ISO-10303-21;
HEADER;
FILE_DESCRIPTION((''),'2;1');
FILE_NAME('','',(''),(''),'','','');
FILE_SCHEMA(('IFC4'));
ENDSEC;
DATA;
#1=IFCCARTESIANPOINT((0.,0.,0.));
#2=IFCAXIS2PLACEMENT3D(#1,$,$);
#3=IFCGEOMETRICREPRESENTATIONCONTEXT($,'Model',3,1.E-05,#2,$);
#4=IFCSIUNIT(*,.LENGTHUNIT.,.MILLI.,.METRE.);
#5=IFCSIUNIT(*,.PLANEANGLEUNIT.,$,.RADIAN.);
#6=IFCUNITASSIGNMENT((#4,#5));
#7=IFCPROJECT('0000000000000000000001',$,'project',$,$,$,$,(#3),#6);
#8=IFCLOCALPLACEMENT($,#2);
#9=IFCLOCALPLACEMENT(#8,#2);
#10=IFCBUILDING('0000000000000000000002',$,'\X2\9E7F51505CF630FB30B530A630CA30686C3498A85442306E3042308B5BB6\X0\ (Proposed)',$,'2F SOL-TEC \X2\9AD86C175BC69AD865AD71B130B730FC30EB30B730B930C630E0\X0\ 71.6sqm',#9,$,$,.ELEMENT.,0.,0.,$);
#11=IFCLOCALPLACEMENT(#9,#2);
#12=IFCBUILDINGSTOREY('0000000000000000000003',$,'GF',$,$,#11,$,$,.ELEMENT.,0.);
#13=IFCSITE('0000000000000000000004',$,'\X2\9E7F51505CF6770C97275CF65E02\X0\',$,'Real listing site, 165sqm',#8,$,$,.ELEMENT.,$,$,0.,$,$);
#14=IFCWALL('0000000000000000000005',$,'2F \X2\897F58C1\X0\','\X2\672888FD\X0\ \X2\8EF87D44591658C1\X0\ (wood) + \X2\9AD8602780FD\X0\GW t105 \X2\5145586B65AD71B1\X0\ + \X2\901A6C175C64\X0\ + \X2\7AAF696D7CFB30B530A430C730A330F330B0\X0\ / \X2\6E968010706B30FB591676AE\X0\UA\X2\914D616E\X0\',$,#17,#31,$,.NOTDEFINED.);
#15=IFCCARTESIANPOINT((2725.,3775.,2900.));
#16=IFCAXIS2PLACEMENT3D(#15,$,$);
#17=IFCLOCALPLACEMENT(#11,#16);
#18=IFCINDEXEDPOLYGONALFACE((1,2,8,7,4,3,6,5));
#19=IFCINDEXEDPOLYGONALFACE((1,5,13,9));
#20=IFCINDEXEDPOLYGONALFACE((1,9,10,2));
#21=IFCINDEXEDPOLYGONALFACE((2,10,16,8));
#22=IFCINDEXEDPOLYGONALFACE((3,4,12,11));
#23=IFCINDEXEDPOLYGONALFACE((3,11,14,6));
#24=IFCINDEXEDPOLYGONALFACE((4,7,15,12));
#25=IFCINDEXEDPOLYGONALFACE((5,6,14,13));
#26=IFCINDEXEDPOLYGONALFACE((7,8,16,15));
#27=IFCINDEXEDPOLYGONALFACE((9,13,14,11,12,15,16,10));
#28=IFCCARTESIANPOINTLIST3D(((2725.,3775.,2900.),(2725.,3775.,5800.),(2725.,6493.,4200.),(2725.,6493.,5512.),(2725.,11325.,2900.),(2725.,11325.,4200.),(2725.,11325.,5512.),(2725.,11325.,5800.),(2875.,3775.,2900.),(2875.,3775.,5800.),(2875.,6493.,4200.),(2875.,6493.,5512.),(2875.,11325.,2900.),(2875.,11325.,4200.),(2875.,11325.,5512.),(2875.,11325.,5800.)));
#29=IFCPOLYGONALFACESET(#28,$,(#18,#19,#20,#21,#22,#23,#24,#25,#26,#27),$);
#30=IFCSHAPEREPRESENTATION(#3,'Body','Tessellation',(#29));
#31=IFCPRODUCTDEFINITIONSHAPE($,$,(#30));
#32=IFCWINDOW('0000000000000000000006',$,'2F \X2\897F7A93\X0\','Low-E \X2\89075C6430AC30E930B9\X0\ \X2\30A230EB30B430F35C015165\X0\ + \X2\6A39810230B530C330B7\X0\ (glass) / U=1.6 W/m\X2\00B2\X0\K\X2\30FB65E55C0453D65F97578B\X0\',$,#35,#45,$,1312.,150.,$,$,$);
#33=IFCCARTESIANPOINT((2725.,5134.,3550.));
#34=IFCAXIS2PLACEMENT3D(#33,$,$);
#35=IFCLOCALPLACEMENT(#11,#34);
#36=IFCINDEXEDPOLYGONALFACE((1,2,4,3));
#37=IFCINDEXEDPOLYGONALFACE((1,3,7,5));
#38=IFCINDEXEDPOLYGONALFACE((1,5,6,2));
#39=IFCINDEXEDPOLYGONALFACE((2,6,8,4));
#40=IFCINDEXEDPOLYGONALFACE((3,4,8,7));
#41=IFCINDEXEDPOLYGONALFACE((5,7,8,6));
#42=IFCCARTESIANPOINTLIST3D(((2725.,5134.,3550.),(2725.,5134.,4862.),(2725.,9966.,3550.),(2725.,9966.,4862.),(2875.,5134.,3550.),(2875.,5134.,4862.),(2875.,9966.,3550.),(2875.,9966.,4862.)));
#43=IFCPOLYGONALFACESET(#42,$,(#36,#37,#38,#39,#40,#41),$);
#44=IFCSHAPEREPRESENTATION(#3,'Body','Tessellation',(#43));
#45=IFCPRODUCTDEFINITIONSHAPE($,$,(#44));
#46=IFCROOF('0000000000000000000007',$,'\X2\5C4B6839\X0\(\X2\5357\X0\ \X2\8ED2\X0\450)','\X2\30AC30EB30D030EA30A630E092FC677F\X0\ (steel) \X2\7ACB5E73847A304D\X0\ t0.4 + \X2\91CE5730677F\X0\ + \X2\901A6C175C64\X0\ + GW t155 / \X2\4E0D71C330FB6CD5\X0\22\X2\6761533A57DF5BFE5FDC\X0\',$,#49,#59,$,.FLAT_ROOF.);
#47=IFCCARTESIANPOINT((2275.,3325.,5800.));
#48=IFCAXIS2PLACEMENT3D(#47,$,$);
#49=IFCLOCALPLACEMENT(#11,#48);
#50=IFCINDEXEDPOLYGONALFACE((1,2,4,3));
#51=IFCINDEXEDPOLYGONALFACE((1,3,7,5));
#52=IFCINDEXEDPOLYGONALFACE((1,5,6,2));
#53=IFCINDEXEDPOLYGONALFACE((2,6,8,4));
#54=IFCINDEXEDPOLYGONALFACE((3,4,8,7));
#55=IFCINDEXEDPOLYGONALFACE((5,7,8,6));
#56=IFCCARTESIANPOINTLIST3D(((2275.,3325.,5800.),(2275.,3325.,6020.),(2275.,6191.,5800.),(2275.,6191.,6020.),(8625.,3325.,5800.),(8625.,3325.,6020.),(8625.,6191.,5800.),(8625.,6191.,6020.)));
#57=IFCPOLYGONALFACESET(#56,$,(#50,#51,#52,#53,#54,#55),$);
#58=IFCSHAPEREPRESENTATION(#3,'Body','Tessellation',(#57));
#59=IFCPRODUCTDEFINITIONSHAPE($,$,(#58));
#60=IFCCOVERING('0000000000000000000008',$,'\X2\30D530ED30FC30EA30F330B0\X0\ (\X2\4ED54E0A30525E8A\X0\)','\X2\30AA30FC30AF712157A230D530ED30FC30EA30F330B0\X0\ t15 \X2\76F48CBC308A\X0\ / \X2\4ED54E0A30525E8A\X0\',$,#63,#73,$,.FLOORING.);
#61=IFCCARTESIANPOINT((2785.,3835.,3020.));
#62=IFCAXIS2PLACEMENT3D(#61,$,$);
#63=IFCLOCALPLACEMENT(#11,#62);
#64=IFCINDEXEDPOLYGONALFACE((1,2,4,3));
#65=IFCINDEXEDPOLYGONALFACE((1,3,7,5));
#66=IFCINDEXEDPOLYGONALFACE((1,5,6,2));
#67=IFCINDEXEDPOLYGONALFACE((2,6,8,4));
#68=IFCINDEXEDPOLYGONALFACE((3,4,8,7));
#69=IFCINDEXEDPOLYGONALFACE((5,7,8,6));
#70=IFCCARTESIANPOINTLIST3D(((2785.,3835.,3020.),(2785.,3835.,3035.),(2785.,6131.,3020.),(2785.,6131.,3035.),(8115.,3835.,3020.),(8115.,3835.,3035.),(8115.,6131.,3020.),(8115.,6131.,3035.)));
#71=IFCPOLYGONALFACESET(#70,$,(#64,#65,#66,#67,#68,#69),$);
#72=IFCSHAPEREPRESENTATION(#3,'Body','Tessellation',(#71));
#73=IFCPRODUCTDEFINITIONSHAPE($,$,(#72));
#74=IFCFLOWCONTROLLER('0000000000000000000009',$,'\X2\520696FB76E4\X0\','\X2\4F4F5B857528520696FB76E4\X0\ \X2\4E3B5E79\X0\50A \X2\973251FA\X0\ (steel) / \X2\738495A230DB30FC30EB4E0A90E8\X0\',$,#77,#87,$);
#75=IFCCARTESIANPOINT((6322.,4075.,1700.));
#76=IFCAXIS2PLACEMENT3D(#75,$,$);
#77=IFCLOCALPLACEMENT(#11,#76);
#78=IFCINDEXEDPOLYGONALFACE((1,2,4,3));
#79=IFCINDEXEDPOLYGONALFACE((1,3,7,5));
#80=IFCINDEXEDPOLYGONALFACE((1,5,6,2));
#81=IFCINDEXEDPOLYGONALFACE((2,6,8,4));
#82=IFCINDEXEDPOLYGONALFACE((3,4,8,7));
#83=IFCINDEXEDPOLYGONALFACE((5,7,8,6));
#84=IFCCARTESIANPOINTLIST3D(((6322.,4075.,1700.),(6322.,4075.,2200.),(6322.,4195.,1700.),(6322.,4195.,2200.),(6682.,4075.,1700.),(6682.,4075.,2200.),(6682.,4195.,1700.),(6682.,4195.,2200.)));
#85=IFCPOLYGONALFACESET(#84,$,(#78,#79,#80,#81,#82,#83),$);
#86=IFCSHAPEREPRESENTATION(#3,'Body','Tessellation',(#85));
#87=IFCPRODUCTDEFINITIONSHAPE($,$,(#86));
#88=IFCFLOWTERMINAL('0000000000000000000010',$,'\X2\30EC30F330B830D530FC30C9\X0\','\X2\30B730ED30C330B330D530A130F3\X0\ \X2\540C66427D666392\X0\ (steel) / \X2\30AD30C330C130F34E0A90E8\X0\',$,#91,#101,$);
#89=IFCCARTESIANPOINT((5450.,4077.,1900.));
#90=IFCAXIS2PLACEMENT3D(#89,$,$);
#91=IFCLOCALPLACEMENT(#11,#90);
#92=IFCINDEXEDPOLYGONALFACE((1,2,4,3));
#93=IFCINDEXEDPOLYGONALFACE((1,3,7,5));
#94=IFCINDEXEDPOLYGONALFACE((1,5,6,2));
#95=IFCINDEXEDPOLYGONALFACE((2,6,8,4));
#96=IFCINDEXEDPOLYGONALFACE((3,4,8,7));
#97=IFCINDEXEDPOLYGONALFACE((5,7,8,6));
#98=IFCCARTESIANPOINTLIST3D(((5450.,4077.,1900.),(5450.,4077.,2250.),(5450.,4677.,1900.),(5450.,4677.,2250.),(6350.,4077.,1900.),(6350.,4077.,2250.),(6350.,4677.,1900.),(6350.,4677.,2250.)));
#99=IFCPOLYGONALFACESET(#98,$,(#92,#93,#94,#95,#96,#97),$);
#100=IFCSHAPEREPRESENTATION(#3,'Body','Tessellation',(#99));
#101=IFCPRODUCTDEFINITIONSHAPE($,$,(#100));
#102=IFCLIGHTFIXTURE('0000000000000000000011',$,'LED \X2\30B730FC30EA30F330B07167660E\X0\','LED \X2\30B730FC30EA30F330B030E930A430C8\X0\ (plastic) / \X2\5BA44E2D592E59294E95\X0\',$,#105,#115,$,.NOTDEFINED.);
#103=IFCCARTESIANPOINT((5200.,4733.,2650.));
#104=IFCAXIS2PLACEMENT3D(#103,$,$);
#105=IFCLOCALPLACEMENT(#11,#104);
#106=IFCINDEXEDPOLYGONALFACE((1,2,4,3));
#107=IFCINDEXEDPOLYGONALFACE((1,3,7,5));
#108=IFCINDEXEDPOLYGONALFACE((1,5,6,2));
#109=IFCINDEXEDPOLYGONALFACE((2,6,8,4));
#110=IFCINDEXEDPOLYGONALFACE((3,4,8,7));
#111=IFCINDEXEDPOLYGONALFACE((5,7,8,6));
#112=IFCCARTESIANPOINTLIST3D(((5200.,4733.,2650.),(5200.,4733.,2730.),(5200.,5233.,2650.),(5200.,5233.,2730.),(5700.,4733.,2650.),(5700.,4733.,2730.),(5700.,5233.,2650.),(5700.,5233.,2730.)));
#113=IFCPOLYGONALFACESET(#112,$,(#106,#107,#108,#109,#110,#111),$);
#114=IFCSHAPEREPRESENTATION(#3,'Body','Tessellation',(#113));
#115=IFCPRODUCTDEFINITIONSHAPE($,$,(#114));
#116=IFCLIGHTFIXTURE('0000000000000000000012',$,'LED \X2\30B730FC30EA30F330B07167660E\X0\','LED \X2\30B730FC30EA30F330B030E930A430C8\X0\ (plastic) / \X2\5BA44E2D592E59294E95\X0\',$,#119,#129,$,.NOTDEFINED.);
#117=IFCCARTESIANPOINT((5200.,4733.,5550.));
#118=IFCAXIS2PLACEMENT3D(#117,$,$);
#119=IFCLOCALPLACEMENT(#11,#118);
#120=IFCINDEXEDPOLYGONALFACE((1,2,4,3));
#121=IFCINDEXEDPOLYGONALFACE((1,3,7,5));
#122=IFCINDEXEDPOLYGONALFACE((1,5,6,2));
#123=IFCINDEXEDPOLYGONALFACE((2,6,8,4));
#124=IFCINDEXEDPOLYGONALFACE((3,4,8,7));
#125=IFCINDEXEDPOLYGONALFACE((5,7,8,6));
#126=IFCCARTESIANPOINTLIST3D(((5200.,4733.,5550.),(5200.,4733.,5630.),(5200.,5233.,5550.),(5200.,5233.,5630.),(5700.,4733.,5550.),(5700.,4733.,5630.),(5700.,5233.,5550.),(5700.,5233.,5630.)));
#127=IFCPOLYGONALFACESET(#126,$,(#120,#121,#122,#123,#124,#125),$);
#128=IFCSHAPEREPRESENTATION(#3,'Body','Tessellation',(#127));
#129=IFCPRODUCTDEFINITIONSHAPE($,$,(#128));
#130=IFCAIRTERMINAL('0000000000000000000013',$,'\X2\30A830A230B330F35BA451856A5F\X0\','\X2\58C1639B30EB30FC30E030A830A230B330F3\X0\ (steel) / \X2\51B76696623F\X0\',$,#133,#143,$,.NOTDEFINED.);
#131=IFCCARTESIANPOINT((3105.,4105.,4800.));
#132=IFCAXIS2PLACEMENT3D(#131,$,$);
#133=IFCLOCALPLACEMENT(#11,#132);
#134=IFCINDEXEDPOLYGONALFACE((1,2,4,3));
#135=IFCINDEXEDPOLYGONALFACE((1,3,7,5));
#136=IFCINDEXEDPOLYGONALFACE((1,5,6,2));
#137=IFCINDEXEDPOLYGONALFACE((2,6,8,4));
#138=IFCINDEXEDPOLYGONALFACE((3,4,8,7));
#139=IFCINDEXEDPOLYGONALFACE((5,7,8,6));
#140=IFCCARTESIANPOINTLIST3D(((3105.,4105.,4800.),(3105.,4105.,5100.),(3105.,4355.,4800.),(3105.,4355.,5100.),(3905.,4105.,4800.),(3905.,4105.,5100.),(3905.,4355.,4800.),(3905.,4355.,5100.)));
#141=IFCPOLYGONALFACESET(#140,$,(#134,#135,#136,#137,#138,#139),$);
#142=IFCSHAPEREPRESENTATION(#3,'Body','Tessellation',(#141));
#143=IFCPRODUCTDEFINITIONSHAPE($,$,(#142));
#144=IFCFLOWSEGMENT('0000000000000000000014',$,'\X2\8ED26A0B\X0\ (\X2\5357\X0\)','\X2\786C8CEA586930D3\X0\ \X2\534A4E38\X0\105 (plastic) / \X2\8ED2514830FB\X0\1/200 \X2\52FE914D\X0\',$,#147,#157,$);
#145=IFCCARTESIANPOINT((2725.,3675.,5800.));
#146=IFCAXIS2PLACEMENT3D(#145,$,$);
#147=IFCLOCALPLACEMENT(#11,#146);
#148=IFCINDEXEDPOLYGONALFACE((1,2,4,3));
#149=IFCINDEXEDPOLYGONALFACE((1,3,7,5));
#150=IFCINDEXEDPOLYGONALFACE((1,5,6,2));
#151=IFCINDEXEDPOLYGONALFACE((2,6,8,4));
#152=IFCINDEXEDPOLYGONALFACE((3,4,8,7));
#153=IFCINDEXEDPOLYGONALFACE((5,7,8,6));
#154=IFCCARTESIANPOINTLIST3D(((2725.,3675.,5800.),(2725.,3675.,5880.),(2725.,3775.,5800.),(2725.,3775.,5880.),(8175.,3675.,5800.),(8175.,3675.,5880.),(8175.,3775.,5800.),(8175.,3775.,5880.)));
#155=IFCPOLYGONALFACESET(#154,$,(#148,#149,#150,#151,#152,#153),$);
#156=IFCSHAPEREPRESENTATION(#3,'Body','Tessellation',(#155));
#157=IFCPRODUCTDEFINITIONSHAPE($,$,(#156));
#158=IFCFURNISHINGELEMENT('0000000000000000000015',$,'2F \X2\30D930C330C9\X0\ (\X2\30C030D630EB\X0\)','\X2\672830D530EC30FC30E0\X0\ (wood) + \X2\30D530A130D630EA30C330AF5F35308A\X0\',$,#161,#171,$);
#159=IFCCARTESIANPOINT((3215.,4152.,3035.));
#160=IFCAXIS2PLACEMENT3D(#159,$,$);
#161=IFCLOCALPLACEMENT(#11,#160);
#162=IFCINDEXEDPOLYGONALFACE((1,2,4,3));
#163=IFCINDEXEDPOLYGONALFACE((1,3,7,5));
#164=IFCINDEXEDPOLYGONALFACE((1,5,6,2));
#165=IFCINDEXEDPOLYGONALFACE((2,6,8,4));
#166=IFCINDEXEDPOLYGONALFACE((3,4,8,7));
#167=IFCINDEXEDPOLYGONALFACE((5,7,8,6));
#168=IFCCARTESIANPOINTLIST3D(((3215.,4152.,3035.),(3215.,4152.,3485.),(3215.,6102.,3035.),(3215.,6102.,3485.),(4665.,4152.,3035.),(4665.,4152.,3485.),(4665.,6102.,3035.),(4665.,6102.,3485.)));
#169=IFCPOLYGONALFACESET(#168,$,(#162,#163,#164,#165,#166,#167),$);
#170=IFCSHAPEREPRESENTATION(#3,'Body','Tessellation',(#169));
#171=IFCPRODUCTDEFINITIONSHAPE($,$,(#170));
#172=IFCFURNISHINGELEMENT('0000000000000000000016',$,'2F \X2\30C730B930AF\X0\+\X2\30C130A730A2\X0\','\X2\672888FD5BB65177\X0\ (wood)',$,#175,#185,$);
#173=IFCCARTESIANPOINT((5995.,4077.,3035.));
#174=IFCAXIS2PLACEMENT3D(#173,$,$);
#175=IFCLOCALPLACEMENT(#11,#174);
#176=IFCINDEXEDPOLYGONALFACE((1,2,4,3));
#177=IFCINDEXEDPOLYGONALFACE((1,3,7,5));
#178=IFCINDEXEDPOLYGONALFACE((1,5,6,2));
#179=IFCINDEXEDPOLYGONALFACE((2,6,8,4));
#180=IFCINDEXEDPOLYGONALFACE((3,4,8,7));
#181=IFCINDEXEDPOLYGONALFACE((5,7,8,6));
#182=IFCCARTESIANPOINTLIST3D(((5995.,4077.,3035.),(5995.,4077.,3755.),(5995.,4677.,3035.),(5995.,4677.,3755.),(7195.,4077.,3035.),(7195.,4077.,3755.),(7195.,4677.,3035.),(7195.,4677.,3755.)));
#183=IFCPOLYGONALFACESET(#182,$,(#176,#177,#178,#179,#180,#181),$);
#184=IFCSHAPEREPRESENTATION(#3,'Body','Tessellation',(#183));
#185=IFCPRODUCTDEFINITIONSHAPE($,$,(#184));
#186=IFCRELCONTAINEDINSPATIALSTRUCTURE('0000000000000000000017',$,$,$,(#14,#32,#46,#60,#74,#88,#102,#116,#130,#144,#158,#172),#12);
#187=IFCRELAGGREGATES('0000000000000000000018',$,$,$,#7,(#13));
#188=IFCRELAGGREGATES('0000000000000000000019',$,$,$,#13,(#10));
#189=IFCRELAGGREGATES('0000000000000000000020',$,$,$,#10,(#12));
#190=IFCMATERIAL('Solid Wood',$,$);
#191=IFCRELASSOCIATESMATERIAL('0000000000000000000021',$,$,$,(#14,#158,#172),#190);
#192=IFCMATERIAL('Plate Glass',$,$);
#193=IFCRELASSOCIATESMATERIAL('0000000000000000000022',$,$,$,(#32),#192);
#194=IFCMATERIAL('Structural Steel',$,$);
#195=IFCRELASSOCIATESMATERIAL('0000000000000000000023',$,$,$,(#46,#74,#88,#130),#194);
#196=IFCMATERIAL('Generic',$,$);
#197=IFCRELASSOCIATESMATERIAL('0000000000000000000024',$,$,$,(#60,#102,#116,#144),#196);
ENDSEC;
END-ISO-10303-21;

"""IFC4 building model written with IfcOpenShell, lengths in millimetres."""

from ifc_helpers import new_model, si_unit, frame, frame_2d, origin, place, context, project, spatial, rectangle, extrude, material, element, fill, save


model = new_model("IFC4")

# Units and contexts
model_context = context("Model", 3, precision=1e-05, world=origin())
ifc_project = project(units=[si_unit("LENGTHUNIT", "METRE", prefix="MILLI"), si_unit("PLANEANGLEUNIT", "RADIAN")], contexts=[model_context])

# Site, building, storey
site_placement = place(None, origin())
site = spatial("IfcSite", under=ifc_project, at=site_placement, Name="鹿児島県霧島市", ObjectType="Real listing site, 165sqm", CompositionType="ELEMENT", RefElevation=0.0)
building_placement = place(site_placement, origin())
building = spatial("IfcBuilding", under=site, at=building_placement, Name="鹿児島・サウナと水風呂のある家 (Proposed)", ObjectType="2F SOL-TEC 高気密高断熱シールシステム 71.6sqm", CompositionType="ELEMENT", ElevationOfRefHeight=0.0, ElevationOfTerrain=0.0)
storey_placement = place(building_placement, origin())
storey = spatial("IfcBuildingStorey", under=building, at=storey_placement, Name="GF", CompositionType="ELEMENT", Elevation=0.0)

# Shared definitions
ifc_material_1 = material(Name="Solid Wood")

# Wall, opening, window
ifc_material_2 = material(Name="Plate Glass")
wall_1_placement = place(storey_placement, frame((2725.0, 3775.0, 2900.0)))
wall_1 = element("IfcWall", 1, at=wall_1_placement, inside=storey, material=ifc_material_1, Name="2F 西壁", Description="木製 軸組外壁 (wood) + 高性能GW t105 充填断熱 + 通気層 + 窯業系サイディング / 準耐火・外皮UA配慮", PredefinedType="NOTDEFINED", context=model_context, shape_type="SweptSolid", body=[
    extrude(rectangle(XDim=150.0, YDim=7550.0, at=frame_2d((75.0, 3775.0))), frame((2725.0, 3775.0, 2900.0)), (0.0, 0.0, 1.0), 2900.0),
])
opening_1_placement = place(storey_placement, frame((2725.0, 5134.0, 3550.0)))
opening_1 = element("IfcOpeningElement", 2, at=opening_1_placement, cuts=wall_1, PredefinedType="NOTDEFINED", context=model_context, shape_type="SweptSolid", body=[
    extrude(rectangle(XDim=150.0, YDim=4832.0, at=frame_2d((75.0, 2416.0))), frame((2725.0, 5134.0, 3550.0)), (0.0, 0.0, 1.0), 1312.0),
])
window_1_placement = place(storey_placement, frame((2725.0, 5134.0, 3550.0)))
window_1 = element("IfcWindow", 3, at=window_1_placement, inside=storey, material=ifc_material_2, Name="2F 西窓", Description="Low-E 複層ガラス アルゴン封入 + 樹脂サッシ (glass) / U=1.6 W/m²K・日射取得型", OverallHeight=1312.0, OverallWidth=150.0, context=model_context, shape_type="SweptSolid", body=[
    extrude(rectangle(XDim=150.0, YDim=4832.0, at=frame_2d((75.0, 2416.0))), frame((2725.0, 5134.0, 3550.0)), (0.0, 0.0, 1.0), 1312.0),
])
fill(opening_1, window_1)

# Roof
ifc_material_3 = material(Name="Structural Steel")
for number, where, name in (
    (4, (2275.0, 3325.0, 5800.0), "屋根(南 軒450)"),
):
    element("IfcRoof", number, at=place(storey_placement, frame(where)), inside=storey, material=ifc_material_3, Name=name, Description="ガルバリウム鋼板 (steel) 立平葺き t0.4 + 野地板 + 通気層 + GW t155 / 不燃・法22条区域対応", PredefinedType="FLAT_ROOF", context=model_context, shape_type="SweptSolid", body=[
        extrude(rectangle(XDim=6350.0, YDim=2866.0, at=frame_2d((3175.0, 1433.0))), frame((2275.0, 3325.0, 5800.0)), (0.0, 0.0, 1.0), 220.0),
    ])

# Covering
ifc_material_4 = material(Name="Generic")
covering_placement = place(storey_placement, frame((2785.0, 3835.0, 3020.0)))
element("IfcCovering", 5, at=covering_placement, inside=storey, material=ifc_material_4, Name="フローリング (仕上げ床)", Description="オーク無垢フローリング t15 直貼り / 仕上げ床", PredefinedType="FLOORING", context=model_context, shape_type="SweptSolid", body=[
    extrude(rectangle(XDim=5330.0, YDim=2296.0, at=frame_2d((2665.0, 1148.0))), frame((2785.0, 3835.0, 3020.0)), (0.0, 0.0, 1.0), 15.0),
])

# Flow controller
flow_controller_placement = place(storey_placement, frame((6322.0, 4075.0, 1700.0)))
element("IfcFlowController", 6, at=flow_controller_placement, inside=storey, material=ifc_material_3, Name="分電盤", Description="住宅用分電盤 主幹50A 露出 (steel) / 玄関ホール上部", context=model_context, shape_type="SweptSolid", body=[
    extrude(rectangle(XDim=360.0, YDim=120.0, at=frame_2d((180.0, 60.0))), frame((6322.0, 4075.0, 1700.0)), (0.0, 0.0, 1.0), 500.0),
])

# Flow terminal
flow_terminal_placement = place(storey_placement, frame((5450.0, 4077.0, 1900.0)))
element("IfcFlowTerminal", 7, at=flow_terminal_placement, inside=storey, material=ifc_material_3, Name="レンジフード", Description="シロッコファン 同時給排 (steel) / キッチン上部", context=model_context, shape_type="SweptSolid", body=[
    extrude(rectangle(XDim=900.0, YDim=600.0, at=frame_2d((450.0, 300.0))), frame((5450.0, 4077.0, 1900.0)), (0.0, 0.0, 1.0), 350.0),
])

# Light fixtures
light_fixture_1_placement = place(storey_placement, frame((5200.0, 4733.0, 2650.0)))
element("IfcLightFixture", 8, at=light_fixture_1_placement, inside=storey, material=ifc_material_4, Name="LED シーリング照明", Description="LED シーリングライト (plastic) / 室中央天井", PredefinedType="NOTDEFINED", context=model_context, shape_type="SweptSolid", body=[
    extrude(rectangle(XDim=500.0, YDim=500.0, at=frame_2d((250.0, 250.0))), frame((5200.0, 4733.0, 2650.0)), (0.0, 0.0, 1.0), 80.0),
])
light_fixture_2_placement = place(storey_placement, frame((5200.0, 4733.0, 5550.0)))
element("IfcLightFixture", 9, at=light_fixture_2_placement, inside=storey, material=ifc_material_4, Name="LED シーリング照明", Description="LED シーリングライト (plastic) / 室中央天井", PredefinedType="NOTDEFINED", context=model_context, shape_type="SweptSolid", body=[
    extrude(rectangle(XDim=500.0, YDim=500.0, at=frame_2d((250.0, 250.0))), frame((5200.0, 4733.0, 5550.0)), (0.0, 0.0, 1.0), 80.0),
])

# Air terminal
air_terminal_placement = place(storey_placement, frame((3105.0, 4105.0, 4800.0)))
element("IfcAirTerminal", 10, at=air_terminal_placement, inside=storey, material=ifc_material_3, Name="エアコン室内機", Description="壁掛ルームエアコン (steel) / 冷暖房", PredefinedType="NOTDEFINED", context=model_context, shape_type="SweptSolid", body=[
    extrude(rectangle(XDim=800.0, YDim=250.0, at=frame_2d((400.0, 125.0))), frame((3105.0, 4105.0, 4800.0)), (0.0, 0.0, 1.0), 300.0),
])

# Flow segment
flow_segment_placement = place(storey_placement, frame((2725.0, 3675.0, 5800.0)))
element("IfcFlowSegment", 11, at=flow_segment_placement, inside=storey, material=ifc_material_4, Name="軒樋 (南)", Description="硬質塩ビ 半丸105 (plastic) / 軒先・1/200 勾配", context=model_context, shape_type="SweptSolid", body=[
    extrude(rectangle(XDim=5450.0, YDim=100.0, at=frame_2d((2725.0, 50.0))), frame((2725.0, 3675.0, 5800.0)), (0.0, 0.0, 1.0), 80.0),
])

# Furnishing elements
furnishing_1_placement = place(storey_placement, frame((3215.0, 4152.0, 3035.0)))
element("IfcFurnishingElement", 12, at=furnishing_1_placement, inside=storey, material=ifc_material_1, Name="2F ベッド (ダブル)", Description="木フレーム (wood) + ファブリック張り", context=model_context, shape_type="SweptSolid", body=[
    extrude(rectangle(XDim=1450.0, YDim=1950.0, at=frame_2d((725.0, 975.0))), frame((3215.0, 4152.0, 3035.0)), (0.0, 0.0, 1.0), 450.0),
])
furnishing_2_placement = place(storey_placement, frame((5995.0, 4077.0, 3035.0)))
element("IfcFurnishingElement", 13, at=furnishing_2_placement, inside=storey, material=ifc_material_1, Name="2F デスク+チェア", Description="木製家具 (wood)", context=model_context, shape_type="SweptSolid", body=[
    extrude(rectangle(XDim=1200.0, YDim=600.0, at=frame_2d((600.0, 300.0))), frame((5995.0, 4077.0, 3035.0)), (0.0, 0.0, 1.0), 720.0),
])

save(model, "model.ifc")
